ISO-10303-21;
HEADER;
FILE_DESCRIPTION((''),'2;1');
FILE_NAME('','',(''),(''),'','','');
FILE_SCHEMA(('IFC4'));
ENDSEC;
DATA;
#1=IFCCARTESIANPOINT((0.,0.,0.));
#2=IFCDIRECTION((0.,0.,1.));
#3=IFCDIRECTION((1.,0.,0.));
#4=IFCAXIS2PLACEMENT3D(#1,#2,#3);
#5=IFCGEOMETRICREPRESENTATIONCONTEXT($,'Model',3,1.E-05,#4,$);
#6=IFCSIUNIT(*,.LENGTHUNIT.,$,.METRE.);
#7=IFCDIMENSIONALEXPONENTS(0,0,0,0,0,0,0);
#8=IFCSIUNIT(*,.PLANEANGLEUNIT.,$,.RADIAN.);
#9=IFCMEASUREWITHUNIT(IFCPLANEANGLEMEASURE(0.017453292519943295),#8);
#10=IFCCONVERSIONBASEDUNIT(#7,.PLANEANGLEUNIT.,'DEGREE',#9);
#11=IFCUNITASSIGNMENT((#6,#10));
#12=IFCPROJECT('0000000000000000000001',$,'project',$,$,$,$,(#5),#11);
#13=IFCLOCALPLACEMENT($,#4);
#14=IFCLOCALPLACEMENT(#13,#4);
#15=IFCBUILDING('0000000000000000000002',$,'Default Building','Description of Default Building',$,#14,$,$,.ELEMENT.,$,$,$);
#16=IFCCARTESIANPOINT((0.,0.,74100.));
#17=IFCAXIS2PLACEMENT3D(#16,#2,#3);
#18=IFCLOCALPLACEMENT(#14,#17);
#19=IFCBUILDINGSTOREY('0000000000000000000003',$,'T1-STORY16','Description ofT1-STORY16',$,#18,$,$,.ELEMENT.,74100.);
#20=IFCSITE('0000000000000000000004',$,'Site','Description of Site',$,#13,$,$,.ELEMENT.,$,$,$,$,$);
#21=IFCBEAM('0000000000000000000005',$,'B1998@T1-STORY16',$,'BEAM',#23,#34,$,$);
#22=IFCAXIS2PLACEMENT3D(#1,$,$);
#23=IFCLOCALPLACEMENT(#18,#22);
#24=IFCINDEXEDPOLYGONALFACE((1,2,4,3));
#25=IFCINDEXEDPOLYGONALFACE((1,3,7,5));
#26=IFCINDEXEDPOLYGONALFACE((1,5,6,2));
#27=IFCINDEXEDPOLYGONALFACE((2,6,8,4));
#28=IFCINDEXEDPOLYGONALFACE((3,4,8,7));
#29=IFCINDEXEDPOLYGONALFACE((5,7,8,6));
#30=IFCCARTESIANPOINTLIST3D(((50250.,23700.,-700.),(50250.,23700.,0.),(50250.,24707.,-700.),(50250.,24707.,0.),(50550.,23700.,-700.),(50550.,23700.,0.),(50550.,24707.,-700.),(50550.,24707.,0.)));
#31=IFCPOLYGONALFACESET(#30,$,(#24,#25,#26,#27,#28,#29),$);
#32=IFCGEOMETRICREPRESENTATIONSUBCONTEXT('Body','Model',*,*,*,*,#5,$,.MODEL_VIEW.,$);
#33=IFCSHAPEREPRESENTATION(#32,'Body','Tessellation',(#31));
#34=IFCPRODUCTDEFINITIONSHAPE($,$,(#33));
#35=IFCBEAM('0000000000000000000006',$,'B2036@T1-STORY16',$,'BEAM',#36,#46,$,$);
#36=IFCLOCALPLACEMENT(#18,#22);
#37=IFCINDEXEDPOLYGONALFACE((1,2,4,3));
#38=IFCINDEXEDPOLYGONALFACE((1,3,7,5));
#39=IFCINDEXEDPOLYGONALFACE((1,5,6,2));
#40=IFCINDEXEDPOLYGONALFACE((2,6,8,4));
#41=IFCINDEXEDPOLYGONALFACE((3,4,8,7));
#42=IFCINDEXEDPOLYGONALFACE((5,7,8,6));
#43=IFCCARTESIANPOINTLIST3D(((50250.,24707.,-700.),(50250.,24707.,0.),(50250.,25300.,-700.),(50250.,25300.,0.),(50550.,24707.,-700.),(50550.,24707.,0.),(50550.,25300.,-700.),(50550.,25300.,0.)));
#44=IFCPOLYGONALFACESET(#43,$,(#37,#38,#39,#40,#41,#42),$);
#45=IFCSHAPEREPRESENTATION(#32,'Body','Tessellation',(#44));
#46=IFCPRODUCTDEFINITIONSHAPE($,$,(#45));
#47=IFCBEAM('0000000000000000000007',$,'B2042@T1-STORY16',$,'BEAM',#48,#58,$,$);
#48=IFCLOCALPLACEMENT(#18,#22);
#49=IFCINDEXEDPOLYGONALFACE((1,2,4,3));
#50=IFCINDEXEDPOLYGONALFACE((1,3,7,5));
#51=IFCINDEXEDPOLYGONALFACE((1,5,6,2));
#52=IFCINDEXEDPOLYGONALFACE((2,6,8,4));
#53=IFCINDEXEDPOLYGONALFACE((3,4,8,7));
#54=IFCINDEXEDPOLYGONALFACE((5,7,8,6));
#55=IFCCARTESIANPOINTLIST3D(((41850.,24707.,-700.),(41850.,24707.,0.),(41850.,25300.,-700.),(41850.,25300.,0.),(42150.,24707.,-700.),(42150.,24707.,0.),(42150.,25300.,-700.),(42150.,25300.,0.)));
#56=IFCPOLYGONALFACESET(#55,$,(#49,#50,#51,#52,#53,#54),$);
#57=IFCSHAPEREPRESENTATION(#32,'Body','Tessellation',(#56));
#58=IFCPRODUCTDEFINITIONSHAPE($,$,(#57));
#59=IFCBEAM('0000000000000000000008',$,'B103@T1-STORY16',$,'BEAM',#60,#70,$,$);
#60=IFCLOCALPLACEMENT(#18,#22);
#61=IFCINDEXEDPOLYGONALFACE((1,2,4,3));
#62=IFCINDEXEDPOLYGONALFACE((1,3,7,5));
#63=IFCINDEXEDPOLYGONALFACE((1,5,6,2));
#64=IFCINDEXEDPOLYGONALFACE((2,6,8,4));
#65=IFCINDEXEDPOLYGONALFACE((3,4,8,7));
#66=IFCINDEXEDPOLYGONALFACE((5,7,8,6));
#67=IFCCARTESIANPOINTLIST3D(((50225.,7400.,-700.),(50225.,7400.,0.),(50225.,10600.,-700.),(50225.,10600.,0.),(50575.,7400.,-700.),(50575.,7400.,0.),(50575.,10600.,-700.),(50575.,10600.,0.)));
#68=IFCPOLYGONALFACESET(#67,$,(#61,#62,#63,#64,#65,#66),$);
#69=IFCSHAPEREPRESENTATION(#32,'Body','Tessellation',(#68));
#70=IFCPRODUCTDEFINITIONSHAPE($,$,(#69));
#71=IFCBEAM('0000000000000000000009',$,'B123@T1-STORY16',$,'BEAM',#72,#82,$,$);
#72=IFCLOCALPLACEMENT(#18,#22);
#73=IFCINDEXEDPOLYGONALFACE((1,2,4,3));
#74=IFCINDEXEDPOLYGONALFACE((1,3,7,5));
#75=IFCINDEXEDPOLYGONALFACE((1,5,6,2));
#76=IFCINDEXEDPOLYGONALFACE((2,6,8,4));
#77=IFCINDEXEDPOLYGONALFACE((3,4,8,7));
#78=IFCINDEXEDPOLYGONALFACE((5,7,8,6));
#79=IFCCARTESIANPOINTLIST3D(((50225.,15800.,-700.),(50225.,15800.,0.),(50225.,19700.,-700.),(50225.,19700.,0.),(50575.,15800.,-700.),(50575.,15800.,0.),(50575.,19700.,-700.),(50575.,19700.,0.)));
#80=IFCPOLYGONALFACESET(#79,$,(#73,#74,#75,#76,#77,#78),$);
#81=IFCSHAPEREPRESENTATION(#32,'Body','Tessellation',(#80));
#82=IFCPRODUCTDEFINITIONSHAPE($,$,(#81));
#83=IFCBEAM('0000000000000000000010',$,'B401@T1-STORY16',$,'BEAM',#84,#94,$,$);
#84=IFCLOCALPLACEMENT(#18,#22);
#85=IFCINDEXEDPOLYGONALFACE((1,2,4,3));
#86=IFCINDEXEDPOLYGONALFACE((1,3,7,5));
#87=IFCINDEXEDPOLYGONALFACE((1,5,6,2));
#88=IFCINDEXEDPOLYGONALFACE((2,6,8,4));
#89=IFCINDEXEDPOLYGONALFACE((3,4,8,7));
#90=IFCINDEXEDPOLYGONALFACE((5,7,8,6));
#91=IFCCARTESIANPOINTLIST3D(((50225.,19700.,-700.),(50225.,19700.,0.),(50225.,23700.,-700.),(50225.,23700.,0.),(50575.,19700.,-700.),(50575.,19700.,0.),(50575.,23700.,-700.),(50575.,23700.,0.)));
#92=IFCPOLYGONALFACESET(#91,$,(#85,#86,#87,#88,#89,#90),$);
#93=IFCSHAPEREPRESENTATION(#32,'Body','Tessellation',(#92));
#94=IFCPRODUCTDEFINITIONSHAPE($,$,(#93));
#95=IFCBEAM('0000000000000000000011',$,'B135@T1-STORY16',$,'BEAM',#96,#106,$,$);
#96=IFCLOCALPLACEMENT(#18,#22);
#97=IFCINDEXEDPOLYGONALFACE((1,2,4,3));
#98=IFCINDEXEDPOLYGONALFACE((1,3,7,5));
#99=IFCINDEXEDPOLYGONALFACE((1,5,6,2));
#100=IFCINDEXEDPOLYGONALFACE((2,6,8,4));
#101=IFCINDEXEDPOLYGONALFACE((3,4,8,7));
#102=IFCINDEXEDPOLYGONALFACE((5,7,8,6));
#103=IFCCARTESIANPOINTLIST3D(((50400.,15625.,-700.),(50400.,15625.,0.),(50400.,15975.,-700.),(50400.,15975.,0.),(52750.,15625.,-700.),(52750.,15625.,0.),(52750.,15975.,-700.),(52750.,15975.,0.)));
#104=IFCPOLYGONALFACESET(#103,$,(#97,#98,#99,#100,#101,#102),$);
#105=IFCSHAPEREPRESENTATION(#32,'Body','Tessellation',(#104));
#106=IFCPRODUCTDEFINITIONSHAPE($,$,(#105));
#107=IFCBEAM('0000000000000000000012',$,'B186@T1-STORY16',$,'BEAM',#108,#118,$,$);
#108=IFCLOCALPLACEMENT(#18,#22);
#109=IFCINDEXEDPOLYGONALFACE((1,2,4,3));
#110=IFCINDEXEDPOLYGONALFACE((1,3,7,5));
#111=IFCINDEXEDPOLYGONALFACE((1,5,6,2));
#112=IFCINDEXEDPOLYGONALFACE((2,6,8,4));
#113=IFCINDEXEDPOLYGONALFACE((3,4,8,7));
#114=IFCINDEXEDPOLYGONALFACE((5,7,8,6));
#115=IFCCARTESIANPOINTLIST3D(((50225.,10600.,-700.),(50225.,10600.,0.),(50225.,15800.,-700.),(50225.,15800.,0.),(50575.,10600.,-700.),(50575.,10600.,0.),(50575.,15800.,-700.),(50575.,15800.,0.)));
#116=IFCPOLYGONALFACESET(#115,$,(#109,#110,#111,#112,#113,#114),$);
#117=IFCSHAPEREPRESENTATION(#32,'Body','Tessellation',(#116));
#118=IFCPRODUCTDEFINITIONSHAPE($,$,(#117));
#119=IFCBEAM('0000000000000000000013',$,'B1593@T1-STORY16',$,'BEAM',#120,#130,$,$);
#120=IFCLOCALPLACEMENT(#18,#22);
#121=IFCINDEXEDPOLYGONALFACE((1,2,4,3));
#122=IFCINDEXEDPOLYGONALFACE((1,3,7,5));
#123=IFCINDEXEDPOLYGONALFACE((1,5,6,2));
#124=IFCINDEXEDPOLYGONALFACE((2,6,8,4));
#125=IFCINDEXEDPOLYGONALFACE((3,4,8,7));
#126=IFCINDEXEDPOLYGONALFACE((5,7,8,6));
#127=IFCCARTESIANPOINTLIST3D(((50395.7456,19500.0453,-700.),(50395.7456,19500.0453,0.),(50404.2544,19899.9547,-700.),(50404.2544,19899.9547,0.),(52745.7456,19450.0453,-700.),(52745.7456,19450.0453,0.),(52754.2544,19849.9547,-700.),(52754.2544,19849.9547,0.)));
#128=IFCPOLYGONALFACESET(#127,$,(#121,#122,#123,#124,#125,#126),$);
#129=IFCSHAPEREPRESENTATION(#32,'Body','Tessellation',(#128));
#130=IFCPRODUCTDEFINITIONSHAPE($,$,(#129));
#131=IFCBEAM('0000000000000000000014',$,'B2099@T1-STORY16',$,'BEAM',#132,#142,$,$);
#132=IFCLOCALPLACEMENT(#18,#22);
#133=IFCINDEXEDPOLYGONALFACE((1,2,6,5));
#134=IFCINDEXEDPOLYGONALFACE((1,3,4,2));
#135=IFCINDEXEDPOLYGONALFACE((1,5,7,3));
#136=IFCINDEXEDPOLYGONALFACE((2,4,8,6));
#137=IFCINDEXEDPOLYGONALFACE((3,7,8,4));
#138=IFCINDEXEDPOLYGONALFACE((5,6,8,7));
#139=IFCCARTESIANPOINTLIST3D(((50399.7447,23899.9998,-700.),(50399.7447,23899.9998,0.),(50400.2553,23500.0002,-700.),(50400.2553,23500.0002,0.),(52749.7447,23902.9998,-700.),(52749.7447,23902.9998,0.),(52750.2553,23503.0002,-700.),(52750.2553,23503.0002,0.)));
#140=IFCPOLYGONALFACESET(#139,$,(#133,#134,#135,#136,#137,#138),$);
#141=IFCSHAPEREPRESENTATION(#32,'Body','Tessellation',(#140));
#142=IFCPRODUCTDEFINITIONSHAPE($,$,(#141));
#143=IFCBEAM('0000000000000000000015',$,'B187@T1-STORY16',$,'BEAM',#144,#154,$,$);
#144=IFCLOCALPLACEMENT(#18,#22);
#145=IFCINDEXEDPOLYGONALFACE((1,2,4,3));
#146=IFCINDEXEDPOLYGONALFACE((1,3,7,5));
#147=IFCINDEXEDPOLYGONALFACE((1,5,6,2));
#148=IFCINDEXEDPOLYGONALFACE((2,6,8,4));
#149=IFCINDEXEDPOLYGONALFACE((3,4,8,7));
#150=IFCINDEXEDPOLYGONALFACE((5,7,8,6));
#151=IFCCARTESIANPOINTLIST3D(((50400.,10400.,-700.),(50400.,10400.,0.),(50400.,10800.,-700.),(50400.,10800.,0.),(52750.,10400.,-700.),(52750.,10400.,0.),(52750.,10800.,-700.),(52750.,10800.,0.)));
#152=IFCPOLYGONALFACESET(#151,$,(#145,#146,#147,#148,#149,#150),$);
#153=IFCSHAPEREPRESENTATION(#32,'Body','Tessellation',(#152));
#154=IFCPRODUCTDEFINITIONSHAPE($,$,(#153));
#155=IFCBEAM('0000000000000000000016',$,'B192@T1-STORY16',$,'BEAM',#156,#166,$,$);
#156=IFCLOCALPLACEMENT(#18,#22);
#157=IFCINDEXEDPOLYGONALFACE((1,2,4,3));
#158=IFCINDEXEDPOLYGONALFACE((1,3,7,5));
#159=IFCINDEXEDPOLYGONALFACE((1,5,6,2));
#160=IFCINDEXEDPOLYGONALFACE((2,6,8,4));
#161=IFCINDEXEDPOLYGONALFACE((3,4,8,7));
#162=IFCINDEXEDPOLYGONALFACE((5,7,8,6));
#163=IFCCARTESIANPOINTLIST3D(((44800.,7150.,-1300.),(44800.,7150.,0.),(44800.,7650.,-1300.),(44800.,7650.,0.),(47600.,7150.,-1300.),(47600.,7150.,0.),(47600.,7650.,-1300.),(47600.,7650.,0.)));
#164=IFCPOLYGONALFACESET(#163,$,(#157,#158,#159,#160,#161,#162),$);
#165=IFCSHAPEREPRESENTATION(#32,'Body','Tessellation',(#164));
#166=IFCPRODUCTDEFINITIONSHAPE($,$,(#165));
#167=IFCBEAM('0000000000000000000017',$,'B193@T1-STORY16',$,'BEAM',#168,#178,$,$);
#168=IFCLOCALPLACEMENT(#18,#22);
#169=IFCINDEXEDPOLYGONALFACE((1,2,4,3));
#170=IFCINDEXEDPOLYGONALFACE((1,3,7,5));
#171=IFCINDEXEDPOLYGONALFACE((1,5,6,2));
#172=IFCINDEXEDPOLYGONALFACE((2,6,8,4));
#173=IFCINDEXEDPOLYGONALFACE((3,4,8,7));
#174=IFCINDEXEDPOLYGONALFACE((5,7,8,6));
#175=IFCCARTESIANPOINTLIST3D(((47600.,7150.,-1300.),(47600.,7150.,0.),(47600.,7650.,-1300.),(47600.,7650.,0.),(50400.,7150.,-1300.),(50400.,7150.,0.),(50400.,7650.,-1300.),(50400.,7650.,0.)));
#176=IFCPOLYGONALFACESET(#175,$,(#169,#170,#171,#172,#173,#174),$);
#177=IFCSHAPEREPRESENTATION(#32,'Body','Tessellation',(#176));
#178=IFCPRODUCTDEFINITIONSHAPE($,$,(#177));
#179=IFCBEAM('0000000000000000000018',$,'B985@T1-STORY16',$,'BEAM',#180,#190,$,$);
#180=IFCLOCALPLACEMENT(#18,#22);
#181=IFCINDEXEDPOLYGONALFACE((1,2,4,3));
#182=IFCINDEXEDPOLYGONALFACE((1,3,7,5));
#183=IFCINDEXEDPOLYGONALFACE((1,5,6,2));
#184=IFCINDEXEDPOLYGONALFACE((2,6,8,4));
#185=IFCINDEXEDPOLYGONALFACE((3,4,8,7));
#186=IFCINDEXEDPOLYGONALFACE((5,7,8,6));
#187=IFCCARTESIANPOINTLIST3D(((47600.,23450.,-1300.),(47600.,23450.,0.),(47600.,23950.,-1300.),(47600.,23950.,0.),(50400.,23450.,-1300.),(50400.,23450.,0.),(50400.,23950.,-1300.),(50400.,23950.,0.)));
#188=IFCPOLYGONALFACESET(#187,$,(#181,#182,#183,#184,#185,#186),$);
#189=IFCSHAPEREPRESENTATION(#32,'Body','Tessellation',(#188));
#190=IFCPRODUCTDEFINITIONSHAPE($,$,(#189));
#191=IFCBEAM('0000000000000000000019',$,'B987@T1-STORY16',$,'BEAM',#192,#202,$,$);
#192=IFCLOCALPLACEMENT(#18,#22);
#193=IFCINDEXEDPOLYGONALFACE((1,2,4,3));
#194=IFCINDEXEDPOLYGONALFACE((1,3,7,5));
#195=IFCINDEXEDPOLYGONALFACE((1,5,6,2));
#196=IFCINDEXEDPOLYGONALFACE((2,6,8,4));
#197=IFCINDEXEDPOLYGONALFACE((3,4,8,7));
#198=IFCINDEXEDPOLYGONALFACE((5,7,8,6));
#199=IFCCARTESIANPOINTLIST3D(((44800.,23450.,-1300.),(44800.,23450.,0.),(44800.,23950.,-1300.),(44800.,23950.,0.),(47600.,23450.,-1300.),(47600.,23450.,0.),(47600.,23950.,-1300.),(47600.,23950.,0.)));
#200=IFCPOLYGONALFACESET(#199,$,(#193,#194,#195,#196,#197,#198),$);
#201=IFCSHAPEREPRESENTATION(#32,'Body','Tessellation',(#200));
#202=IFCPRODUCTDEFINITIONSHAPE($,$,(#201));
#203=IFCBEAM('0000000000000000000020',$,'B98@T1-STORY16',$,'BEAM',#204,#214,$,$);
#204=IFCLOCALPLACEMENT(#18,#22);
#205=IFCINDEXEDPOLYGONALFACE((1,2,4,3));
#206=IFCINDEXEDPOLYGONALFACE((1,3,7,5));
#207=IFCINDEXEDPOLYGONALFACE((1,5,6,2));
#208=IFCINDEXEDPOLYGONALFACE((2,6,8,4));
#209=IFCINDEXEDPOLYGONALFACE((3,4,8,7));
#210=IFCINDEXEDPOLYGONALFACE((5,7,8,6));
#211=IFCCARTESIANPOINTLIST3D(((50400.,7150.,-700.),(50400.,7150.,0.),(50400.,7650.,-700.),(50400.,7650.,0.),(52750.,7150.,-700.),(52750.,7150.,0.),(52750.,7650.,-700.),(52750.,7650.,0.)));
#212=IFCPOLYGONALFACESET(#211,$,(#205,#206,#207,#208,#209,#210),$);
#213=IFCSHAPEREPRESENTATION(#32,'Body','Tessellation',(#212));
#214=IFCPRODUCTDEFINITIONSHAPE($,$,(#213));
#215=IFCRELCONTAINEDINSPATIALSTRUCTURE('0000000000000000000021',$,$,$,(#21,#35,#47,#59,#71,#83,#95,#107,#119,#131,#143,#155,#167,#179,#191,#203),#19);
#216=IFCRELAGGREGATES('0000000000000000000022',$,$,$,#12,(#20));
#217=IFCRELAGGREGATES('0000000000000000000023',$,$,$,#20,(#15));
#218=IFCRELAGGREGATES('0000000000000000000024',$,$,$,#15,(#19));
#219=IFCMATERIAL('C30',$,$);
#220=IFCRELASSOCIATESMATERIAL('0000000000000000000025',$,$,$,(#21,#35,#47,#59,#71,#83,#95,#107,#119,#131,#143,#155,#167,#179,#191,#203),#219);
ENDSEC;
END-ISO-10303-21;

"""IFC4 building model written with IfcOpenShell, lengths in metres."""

from ifc_helpers import new_model, entity, si_unit, converted_unit, frame, origin_with_axes, place, context, subcontext, project, spatial, rectangle, extrude, material, element, save


model = new_model("IFC4")

# Units and contexts
model_context = context("Model", 3, precision=1e-05, world=origin_with_axes())
body_context = subcontext(model_context, "Body", "Model", "MODEL_VIEW")
ifc_project = project(units=[si_unit("LENGTHUNIT", "METRE"), converted_unit("PLANEANGLEUNIT", "DEGREE", entity("IfcPlaneAngleMeasure", 0.017453292519943295), si_unit("PLANEANGLEUNIT", "RADIAN"), dimensions=[0, 0, 0, 0, 0, 0, 0])], contexts=[model_context])

# Site, building, storey
site_placement = place(None, origin_with_axes())
site = spatial("IfcSite", under=ifc_project, at=site_placement, Name="Site", Description="Description of Site", CompositionType="ELEMENT")
building_placement = place(site_placement, origin_with_axes())
building = spatial("IfcBuilding", under=site, at=building_placement, Name="Default Building", Description="Description of Default Building", CompositionType="ELEMENT")
storey_placement = place(building_placement, frame((0.0, 0.0, 74100.0), z_axis=(0.0, 0.0, 1.0), x_axis=(1.0, 0.0, 0.0)))
storey = spatial("IfcBuildingStorey", under=building, at=storey_placement, Name="T1-STORY16", Description="Description ofT1-STORY16", CompositionType="ELEMENT", Elevation=74100.0)

# Beams
ifc_material_1 = material(Name="C30")
beam_1_placement = place(storey_placement, frame((50400.0, 23700.0, -350.0), z_axis=(0.0, 1.0, 0.0), x_axis=(-1.0, 0.0, 0.0)))
element("IfcBeam", 1, at=beam_1_placement, inside=storey, material=ifc_material_1, Name="B1998@T1-STORY16", ObjectType="BEAM", context=body_context, shape_type="SweptSolid", body=[
    extrude(rectangle(XDim=300.0, YDim=700.0), origin_with_axes(), (0.0, 0.0, 1.0), 1007.0),
])
for number, where, z_axis, x_axis, name in (
    (2, (50400.0, 24707.0, -350.0), (0.0, 1.0, 0.0), (-1.0, 0.0, 0.0), "B2036@T1-STORY16"),
    (3, (42000.0, 24707.0, -350.0), (0.0, 1.0, 0.0), (-1.0, 0.0, 0.0), "B2042@T1-STORY16"),
):
    element("IfcBeam", number, at=place(storey_placement, frame(where, z_axis=z_axis, x_axis=x_axis)), inside=storey, material=ifc_material_1, Name=name, ObjectType="BEAM", context=body_context, shape_type="SweptSolid", body=[
        extrude(rectangle(XDim=300.0, YDim=700.0), origin_with_axes(), (0.0, 0.0, 1.0), 593.0),
    ])
beam_2_placement = place(storey_placement, frame((50400.0, 7400.0, -350.0), z_axis=(0.0, 1.0, 0.0), x_axis=(-1.0, 0.0, 0.0)))
element("IfcBeam", 4, at=beam_2_placement, inside=storey, material=ifc_material_1, Name="B103@T1-STORY16", ObjectType="BEAM", context=body_context, shape_type="SweptSolid", body=[
    extrude(rectangle(XDim=350.0, YDim=700.0), origin_with_axes(), (0.0, 0.0, 1.0), 3200.0),
])
beam_3_placement = place(storey_placement, frame((50400.0, 15800.0, -350.0), z_axis=(0.0, 1.0, 0.0), x_axis=(-1.0, 0.0, 0.0)))
element("IfcBeam", 5, at=beam_3_placement, inside=storey, material=ifc_material_1, Name="B123@T1-STORY16", ObjectType="BEAM", context=body_context, shape_type="SweptSolid", body=[
    extrude(rectangle(XDim=350.0, YDim=700.0), origin_with_axes(), (0.0, 0.0, 1.0), 3900.0),
])
beam_4_placement = place(storey_placement, frame((50400.0, 19700.0, -350.0), z_axis=(0.0, 1.0, 0.0), x_axis=(-1.0, 0.0, 0.0)))
element("IfcBeam", 6, at=beam_4_placement, inside=storey, material=ifc_material_1, Name="B401@T1-STORY16", ObjectType="BEAM", context=body_context, shape_type="SweptSolid", body=[
    extrude(rectangle(XDim=350.0, YDim=700.0), origin_with_axes(), (0.0, 0.0, 1.0), 4000.0),
])
beam_5_placement = place(storey_placement, frame((50400.0, 15800.0, -350.0), z_axis=(1.0, 0.0, 0.0), x_axis=(0.0, 1.0, 0.0)))
element("IfcBeam", 7, at=beam_5_placement, inside=storey, material=ifc_material_1, Name="B135@T1-STORY16", ObjectType="BEAM", context=body_context, shape_type="SweptSolid", body=[
    extrude(rectangle(XDim=350.0, YDim=700.0), origin_with_axes(), (0.0, 0.0, 1.0), 2350.0),
])
beam_6_placement = place(storey_placement, frame((50400.0, 10600.0, -350.0), z_axis=(0.0, 1.0, 0.0), x_axis=(-1.0, 0.0, 0.0)))
element("IfcBeam", 8, at=beam_6_placement, inside=storey, material=ifc_material_1, Name="B186@T1-STORY16", ObjectType="BEAM", context=body_context, shape_type="SweptSolid", body=[
    extrude(rectangle(XDim=350.0, YDim=700.0), origin_with_axes(), (0.0, 0.0, 1.0), 5200.0),
])
beam_7_placement = place(storey_placement, frame((50400.0, 19700.0, -350.0), z_axis=(0.999774, -0.021272, 0.0), x_axis=(0.021272, 0.999774, 0.0)))
element("IfcBeam", 9, at=beam_7_placement, inside=storey, material=ifc_material_1, Name="B1593@T1-STORY16", ObjectType="BEAM", context=body_context, shape_type="SweptSolid", body=[
    extrude(rectangle(XDim=400.0, YDim=700.0), origin_with_axes(), (0.0, 0.0, 1.0), 2350.5319),
])
beam_8_placement = place(storey_placement, frame((50400.0, 23700.0, -350.0), z_axis=(0.999999, 0.001277, 0.0), x_axis=(-0.001277, 0.999999, 0.0)))
element("IfcBeam", 10, at=beam_8_placement, inside=storey, material=ifc_material_1, Name="B2099@T1-STORY16", ObjectType="BEAM", context=body_context, shape_type="SweptSolid", body=[
    extrude(rectangle(XDim=400.0, YDim=700.0), origin_with_axes(), (0.0, 0.0, 1.0), 2350.0019),
])
beam_9_placement = place(storey_placement, frame((50400.0, 10600.0, -350.0), z_axis=(1.0, 0.0, 0.0), x_axis=(0.0, 1.0, 0.0)))
element("IfcBeam", 11, at=beam_9_placement, inside=storey, material=ifc_material_1, Name="B187@T1-STORY16", ObjectType="BEAM", context=body_context, shape_type="SweptSolid", body=[
    extrude(rectangle(XDim=400.0, YDim=700.0), origin_with_axes(), (0.0, 0.0, 1.0), 2350.0),
])
for number, where, z_axis, x_axis, name in (
    (12, (44800.0, 7400.0, -650.0), (1.0, 0.0, 0.0), (0.0, 1.0, 0.0), "B192@T1-STORY16"),
    (13, (47600.0, 7400.0, -650.0), (1.0, 0.0, 0.0), (0.0, 1.0, 0.0), "B193@T1-STORY16"),
    (14, (47600.0, 23700.0, -650.0), (1.0, 0.0, 0.0), (0.0, 1.0, 0.0), "B985@T1-STORY16"),
    (15, (44800.0, 23700.0, -650.0), (1.0, 0.0, 0.0), (0.0, 1.0, 0.0), "B987@T1-STORY16"),
):
    element("IfcBeam", number, at=place(storey_placement, frame(where, z_axis=z_axis, x_axis=x_axis)), inside=storey, material=ifc_material_1, Name=name, ObjectType="BEAM", context=body_context, shape_type="SweptSolid", body=[
        extrude(rectangle(XDim=500.0, YDim=1300.0), origin_with_axes(), (0.0, 0.0, 1.0), 2800.0),
    ])
beam_10_placement = place(storey_placement, frame((50400.0, 7400.0, -350.0), z_axis=(1.0, 0.0, 0.0), x_axis=(0.0, 1.0, 0.0)))
element("IfcBeam", 16, at=beam_10_placement, inside=storey, material=ifc_material_1, Name="B98@T1-STORY16", ObjectType="BEAM", context=body_context, shape_type="SweptSolid", body=[
    extrude(rectangle(XDim=500.0, YDim=700.0), origin_with_axes(), (0.0, 0.0, 1.0), 2350.0),
])

save(model, "model.ifc")
